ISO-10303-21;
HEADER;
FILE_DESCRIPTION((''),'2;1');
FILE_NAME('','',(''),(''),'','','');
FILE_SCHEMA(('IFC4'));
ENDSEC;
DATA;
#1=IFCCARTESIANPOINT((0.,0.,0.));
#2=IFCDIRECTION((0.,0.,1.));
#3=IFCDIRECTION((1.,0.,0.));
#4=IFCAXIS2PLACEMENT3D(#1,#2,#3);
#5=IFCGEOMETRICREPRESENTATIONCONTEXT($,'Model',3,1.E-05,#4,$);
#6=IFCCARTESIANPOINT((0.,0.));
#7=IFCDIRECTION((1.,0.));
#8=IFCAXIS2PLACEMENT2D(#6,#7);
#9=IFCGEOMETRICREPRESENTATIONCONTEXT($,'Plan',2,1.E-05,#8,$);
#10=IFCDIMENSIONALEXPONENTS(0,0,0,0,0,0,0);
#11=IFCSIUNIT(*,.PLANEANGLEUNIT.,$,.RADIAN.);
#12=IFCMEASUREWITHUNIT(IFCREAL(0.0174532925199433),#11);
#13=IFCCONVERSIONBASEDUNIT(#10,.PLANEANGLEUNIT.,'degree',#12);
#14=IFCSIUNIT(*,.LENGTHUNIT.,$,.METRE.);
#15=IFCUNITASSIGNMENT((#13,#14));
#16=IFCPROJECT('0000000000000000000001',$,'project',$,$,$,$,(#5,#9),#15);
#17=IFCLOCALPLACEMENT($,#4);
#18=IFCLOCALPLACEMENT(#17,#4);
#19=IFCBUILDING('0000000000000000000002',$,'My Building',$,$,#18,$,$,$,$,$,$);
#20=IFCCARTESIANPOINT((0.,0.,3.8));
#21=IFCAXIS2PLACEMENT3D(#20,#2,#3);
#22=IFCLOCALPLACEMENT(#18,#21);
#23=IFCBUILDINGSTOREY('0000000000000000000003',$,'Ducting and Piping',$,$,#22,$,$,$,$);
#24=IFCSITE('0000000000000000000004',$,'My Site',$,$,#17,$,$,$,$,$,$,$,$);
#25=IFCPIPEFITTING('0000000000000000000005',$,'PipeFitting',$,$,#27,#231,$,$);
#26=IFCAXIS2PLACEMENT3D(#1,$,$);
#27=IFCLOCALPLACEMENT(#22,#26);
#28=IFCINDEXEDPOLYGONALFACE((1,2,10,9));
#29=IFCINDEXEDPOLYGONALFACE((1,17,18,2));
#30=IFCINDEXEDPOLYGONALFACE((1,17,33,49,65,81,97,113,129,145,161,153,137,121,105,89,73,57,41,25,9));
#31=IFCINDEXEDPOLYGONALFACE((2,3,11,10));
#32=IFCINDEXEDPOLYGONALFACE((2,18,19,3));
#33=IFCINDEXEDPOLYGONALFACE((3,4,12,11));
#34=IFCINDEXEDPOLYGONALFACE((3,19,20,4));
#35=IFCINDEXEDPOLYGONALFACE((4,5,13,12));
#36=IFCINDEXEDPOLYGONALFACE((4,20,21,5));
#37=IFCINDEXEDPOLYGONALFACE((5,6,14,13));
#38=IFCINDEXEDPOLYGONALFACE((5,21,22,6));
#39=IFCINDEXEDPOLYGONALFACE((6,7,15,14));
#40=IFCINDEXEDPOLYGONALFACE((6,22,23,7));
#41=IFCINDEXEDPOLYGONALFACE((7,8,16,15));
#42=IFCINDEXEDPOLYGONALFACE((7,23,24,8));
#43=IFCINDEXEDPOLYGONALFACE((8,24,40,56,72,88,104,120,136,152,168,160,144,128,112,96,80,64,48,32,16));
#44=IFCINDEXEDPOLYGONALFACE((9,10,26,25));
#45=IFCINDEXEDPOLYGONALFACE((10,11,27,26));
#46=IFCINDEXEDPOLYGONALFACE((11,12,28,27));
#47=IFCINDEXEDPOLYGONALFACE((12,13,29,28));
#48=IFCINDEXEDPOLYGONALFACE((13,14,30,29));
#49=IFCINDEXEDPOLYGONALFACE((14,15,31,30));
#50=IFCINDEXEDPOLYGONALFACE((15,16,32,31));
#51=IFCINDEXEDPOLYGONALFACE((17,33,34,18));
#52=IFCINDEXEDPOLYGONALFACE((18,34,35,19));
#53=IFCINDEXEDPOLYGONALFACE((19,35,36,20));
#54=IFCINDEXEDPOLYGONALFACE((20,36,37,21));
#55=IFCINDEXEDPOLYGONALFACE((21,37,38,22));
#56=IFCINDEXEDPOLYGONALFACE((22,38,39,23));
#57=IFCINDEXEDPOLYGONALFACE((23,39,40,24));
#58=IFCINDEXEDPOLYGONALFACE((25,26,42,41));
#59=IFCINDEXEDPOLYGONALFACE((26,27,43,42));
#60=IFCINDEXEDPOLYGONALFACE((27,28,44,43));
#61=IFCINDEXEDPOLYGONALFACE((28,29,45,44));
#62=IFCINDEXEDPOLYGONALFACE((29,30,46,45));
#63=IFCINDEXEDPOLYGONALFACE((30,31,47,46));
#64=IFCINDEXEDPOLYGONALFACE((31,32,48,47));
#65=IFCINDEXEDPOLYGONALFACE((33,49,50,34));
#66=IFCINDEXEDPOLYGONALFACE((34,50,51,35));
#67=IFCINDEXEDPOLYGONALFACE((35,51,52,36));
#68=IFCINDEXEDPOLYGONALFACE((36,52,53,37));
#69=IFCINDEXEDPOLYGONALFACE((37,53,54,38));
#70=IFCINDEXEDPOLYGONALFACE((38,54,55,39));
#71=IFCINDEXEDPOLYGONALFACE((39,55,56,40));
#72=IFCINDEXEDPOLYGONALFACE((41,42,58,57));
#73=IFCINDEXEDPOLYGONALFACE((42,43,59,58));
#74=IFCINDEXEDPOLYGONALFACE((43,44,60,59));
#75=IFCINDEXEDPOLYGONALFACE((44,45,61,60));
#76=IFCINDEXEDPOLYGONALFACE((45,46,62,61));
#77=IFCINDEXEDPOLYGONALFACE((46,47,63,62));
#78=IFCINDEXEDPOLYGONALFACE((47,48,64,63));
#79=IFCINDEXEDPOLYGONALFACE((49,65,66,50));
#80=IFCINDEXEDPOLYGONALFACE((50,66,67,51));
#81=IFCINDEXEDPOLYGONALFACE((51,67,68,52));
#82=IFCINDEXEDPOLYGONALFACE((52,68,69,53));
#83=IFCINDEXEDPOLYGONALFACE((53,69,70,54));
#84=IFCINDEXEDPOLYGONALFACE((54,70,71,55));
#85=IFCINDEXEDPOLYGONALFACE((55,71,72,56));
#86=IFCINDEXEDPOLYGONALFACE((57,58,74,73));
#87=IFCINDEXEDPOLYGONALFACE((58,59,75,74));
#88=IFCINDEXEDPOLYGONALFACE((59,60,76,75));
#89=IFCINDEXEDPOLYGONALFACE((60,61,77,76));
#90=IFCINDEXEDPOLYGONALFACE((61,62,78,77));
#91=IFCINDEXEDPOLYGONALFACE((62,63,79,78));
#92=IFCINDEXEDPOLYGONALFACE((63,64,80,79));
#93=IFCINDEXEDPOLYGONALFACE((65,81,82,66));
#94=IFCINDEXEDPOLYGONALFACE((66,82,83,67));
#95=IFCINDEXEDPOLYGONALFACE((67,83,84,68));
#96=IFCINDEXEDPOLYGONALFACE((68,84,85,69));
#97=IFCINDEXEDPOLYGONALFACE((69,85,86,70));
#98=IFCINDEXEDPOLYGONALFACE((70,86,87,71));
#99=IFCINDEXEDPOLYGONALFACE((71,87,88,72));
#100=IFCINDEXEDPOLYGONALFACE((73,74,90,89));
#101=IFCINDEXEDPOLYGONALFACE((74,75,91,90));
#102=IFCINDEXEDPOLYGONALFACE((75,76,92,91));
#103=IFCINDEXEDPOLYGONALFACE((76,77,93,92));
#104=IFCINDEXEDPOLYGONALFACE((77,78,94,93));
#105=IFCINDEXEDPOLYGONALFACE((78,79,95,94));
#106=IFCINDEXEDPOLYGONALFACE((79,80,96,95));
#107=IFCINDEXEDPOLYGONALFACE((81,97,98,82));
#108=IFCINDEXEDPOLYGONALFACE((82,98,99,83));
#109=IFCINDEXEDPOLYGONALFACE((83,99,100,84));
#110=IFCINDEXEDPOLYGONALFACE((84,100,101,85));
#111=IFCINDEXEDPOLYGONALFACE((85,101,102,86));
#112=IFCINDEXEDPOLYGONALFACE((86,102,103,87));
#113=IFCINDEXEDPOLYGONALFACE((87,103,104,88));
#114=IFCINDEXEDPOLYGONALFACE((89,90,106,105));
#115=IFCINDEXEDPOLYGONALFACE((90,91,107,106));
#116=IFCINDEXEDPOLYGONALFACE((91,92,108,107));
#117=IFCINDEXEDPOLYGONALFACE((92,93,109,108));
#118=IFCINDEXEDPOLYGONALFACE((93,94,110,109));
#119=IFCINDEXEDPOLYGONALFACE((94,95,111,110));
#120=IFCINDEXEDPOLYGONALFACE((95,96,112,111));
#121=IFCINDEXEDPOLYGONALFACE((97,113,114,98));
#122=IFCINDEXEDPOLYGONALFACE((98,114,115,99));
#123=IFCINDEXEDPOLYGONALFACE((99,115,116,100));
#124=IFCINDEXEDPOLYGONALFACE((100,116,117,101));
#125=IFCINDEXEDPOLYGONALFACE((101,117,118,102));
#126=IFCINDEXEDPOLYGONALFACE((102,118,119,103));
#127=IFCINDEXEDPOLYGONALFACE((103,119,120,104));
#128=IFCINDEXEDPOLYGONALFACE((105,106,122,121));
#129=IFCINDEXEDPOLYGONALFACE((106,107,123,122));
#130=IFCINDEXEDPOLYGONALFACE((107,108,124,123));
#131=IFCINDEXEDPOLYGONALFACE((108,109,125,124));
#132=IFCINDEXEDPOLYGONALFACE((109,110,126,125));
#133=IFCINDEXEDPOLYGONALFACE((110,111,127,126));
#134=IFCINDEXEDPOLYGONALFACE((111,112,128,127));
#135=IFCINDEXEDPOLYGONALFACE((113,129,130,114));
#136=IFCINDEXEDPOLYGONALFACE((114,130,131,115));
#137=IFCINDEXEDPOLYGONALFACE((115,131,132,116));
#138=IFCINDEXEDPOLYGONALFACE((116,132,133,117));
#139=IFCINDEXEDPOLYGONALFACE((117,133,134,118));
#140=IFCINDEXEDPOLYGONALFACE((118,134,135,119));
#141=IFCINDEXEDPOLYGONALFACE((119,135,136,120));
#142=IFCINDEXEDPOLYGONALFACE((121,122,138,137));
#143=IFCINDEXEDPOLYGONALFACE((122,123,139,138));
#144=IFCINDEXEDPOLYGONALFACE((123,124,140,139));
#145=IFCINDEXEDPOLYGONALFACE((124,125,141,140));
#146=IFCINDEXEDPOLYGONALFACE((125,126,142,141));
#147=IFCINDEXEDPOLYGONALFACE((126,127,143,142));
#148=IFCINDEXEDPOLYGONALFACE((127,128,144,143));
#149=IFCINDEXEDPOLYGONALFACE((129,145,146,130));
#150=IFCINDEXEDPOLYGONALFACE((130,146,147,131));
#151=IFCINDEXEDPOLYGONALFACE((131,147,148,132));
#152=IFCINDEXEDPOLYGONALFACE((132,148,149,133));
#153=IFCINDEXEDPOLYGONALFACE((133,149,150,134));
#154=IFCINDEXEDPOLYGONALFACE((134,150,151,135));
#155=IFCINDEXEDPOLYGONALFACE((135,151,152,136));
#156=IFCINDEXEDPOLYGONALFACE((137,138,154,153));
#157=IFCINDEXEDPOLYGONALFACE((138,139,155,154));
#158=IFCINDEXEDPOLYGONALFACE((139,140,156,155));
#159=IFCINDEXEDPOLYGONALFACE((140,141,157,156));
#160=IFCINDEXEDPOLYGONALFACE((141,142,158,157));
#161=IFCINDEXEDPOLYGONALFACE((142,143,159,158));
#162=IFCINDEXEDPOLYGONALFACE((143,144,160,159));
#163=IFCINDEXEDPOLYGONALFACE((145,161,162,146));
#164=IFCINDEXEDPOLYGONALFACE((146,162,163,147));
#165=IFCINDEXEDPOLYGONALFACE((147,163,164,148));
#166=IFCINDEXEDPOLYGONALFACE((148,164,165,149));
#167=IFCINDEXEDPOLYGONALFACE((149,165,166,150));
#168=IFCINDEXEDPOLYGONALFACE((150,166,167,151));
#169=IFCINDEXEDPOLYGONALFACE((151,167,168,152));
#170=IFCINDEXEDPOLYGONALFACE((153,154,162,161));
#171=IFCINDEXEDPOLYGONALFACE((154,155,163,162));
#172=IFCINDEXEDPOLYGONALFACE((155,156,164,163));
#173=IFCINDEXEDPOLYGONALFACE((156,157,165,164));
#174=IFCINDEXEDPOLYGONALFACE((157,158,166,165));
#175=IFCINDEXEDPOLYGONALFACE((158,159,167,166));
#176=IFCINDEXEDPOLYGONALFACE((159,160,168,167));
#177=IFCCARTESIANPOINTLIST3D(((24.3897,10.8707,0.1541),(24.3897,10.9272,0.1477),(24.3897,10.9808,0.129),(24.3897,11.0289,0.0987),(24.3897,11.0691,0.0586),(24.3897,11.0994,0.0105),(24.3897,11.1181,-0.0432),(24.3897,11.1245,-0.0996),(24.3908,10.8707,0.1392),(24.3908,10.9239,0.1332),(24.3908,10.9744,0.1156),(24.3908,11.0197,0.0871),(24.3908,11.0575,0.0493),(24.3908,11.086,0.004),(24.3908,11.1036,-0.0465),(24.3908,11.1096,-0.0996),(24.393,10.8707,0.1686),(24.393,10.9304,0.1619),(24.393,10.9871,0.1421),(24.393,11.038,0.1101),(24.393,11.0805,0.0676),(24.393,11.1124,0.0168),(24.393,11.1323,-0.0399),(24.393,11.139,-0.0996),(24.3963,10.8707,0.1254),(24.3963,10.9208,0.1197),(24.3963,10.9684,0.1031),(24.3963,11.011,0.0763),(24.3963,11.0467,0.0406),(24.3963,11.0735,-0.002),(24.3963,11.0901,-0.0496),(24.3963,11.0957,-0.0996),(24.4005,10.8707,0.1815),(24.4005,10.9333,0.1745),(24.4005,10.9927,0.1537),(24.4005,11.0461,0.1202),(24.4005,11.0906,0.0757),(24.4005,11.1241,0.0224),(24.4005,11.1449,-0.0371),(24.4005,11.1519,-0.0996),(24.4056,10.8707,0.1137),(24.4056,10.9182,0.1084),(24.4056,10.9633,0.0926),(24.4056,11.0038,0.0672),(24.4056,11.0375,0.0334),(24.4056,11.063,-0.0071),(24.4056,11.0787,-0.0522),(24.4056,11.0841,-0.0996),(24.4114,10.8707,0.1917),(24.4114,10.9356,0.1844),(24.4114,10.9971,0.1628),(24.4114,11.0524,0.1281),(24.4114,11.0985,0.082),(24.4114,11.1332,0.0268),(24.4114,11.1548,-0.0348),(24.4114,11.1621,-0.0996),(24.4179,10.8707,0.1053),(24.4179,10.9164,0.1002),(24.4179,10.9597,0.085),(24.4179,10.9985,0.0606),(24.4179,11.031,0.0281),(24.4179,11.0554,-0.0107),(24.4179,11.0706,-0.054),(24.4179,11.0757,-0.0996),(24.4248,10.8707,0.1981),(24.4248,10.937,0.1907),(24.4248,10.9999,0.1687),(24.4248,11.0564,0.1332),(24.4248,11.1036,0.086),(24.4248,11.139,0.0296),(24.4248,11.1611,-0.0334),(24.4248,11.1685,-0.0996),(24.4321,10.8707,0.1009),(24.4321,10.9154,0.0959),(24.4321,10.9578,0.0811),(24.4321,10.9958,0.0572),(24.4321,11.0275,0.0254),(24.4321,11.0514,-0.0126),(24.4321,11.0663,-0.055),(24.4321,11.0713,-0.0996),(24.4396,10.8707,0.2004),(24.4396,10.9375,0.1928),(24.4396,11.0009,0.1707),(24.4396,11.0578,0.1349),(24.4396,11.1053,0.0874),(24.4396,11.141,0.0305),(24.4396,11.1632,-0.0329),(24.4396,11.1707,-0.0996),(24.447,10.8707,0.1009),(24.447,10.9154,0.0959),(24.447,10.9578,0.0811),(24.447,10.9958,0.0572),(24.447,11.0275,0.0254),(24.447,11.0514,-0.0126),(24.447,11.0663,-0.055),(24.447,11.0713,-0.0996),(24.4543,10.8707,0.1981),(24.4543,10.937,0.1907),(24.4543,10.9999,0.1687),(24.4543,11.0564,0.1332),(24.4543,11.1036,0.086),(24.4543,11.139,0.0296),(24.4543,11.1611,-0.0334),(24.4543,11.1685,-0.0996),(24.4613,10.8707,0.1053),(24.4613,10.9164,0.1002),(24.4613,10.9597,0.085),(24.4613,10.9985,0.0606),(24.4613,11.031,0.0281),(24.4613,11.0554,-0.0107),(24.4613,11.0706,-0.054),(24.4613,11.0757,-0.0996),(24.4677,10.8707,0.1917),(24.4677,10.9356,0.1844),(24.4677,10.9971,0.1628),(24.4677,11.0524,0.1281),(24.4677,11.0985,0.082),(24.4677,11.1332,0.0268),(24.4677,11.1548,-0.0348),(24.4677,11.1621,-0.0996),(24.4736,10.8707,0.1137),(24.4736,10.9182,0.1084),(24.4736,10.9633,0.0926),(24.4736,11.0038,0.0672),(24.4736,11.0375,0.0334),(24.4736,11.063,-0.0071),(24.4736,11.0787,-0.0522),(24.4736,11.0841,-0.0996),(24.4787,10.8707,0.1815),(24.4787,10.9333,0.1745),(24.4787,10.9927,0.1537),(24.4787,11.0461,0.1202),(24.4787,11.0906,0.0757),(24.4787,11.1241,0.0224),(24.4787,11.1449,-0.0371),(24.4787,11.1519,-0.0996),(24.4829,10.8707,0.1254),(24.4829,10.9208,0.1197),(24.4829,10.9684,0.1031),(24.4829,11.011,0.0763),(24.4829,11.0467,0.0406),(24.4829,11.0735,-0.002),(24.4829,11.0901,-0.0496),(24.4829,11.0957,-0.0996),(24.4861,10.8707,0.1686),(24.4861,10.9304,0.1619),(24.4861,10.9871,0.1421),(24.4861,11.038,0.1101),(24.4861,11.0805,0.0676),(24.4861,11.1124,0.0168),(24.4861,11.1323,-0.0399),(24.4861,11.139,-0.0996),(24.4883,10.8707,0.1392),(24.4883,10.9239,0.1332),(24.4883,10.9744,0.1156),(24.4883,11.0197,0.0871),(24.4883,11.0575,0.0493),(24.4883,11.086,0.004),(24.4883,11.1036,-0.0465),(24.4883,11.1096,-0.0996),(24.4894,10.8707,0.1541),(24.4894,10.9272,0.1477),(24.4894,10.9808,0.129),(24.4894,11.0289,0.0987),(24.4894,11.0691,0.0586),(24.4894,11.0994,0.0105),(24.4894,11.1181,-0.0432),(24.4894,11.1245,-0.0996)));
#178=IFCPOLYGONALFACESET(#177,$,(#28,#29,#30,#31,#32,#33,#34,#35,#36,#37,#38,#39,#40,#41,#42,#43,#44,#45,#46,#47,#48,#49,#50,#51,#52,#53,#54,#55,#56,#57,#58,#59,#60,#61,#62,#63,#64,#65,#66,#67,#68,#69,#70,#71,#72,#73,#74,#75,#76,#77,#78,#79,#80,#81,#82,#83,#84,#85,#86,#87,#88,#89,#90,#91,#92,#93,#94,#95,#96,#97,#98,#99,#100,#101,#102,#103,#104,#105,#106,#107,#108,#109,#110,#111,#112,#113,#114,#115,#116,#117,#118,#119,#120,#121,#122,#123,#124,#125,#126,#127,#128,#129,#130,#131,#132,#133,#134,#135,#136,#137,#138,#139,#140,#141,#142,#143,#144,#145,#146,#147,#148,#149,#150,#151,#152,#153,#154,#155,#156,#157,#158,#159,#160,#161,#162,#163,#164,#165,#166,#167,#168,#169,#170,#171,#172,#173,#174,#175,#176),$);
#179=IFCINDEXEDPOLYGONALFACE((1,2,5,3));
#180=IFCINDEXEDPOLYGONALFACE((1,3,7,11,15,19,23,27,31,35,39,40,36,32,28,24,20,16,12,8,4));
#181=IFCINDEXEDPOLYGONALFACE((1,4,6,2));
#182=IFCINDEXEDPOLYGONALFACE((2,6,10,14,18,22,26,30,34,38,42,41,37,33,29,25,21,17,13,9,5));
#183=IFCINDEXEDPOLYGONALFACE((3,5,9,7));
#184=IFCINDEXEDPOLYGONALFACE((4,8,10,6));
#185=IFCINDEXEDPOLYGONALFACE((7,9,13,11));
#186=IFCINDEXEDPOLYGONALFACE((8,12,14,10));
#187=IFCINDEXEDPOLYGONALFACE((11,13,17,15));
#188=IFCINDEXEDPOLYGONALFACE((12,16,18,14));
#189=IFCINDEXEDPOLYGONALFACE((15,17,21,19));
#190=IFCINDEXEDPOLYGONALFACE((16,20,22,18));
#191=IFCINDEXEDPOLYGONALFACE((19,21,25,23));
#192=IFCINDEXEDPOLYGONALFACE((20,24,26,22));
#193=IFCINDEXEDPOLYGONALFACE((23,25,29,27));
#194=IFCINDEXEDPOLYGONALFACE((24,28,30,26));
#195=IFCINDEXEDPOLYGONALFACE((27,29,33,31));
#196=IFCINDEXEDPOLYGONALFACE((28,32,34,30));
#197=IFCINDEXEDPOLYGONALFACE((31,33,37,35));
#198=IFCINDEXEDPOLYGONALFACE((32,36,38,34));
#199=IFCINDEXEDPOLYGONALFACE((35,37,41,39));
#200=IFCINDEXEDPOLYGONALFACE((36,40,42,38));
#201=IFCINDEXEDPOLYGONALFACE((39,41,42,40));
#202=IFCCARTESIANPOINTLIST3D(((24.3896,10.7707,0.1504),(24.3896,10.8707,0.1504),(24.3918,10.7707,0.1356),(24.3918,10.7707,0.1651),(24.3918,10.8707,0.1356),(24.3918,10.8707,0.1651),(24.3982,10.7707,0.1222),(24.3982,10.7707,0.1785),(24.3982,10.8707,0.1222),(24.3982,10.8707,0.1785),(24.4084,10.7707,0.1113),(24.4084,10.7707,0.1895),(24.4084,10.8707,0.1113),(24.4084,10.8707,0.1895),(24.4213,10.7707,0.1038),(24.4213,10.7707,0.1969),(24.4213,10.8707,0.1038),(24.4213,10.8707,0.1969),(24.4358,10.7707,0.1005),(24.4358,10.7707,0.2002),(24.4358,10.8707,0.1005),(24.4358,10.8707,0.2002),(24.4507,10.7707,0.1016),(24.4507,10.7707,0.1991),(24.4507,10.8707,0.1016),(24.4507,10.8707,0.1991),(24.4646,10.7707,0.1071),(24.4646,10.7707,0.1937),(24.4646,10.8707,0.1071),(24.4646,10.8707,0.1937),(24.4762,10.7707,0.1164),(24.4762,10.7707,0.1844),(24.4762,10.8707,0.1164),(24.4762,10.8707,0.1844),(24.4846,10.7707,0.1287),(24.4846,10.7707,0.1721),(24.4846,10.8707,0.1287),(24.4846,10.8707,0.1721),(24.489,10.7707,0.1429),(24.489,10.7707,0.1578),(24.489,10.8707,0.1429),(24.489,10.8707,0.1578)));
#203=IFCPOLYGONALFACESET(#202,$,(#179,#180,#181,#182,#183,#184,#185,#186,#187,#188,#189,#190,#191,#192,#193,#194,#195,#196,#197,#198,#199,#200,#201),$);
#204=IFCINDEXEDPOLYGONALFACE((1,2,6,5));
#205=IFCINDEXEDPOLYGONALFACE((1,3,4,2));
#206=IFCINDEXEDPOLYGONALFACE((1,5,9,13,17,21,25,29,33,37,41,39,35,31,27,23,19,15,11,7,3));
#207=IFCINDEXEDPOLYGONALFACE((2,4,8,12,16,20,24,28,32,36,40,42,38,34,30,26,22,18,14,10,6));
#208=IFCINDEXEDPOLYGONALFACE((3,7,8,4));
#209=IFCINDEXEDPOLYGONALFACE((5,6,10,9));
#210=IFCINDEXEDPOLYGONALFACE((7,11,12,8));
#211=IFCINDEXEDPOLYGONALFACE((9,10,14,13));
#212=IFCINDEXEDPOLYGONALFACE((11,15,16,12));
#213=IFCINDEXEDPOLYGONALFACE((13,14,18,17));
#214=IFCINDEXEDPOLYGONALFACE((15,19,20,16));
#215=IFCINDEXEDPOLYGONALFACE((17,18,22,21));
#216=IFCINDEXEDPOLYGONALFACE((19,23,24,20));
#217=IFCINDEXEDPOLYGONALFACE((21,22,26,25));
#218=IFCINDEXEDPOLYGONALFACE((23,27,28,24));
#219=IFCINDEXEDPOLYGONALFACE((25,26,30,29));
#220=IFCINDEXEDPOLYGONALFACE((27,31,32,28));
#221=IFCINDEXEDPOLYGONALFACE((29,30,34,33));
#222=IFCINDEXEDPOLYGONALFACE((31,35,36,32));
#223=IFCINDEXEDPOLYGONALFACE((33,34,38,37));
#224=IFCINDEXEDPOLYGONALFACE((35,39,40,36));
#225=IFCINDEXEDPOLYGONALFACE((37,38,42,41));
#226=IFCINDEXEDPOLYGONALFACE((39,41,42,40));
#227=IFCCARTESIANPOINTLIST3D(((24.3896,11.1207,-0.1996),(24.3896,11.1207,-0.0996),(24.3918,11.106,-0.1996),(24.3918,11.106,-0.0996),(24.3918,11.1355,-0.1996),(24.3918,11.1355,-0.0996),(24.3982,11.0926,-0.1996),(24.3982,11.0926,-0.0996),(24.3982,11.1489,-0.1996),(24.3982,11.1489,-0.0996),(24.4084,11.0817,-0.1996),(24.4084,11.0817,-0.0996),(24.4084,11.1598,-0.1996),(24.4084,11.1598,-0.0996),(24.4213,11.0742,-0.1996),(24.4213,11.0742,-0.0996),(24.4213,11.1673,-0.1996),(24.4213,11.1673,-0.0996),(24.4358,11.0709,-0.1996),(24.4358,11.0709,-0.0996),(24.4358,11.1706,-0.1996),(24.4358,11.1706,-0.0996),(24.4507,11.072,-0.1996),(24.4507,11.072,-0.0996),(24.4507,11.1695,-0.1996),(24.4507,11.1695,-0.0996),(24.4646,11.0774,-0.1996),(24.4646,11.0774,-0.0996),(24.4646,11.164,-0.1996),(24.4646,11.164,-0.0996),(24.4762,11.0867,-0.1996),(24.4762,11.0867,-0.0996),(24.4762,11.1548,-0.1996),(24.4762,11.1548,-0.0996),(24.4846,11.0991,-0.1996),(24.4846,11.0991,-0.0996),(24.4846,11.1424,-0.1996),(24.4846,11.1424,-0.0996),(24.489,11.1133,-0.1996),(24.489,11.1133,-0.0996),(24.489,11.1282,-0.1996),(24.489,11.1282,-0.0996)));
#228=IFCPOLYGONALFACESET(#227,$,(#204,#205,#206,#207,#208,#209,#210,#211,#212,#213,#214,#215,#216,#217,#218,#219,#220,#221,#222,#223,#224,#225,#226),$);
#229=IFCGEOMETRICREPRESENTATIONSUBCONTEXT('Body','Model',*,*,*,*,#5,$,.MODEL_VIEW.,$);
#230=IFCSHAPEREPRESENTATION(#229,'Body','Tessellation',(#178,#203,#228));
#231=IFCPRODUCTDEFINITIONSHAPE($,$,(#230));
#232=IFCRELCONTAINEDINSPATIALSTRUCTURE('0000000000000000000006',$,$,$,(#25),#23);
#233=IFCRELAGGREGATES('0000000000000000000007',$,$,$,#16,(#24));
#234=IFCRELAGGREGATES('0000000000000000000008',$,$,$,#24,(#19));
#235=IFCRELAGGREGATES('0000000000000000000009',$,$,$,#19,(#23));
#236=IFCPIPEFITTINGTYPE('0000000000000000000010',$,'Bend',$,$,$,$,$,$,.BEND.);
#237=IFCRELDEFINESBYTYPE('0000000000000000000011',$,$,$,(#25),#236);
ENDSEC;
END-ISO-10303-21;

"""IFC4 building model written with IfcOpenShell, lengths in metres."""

from ifc_helpers import new_model, entity, si_unit, converted_unit, frame, origin_with_axes, origin_2d_with_axis, place, context, subcontext, project, spatial, circle, extrude, source, transform, mapped, type_object, type_shapes, element, save


model = new_model("IFC4")

# Units and contexts
model_context = context("Model", 3, precision=1e-05, world=origin_with_axes())
plan_context = context("Plan", 2, precision=1e-05, world=origin_2d_with_axis())
body_context = subcontext(model_context, "Body", "Model", "MODEL_VIEW")
ifc_project = project(units=[converted_unit("PLANEANGLEUNIT", "degree", entity("IfcReal", 0.0174532925199433), si_unit("PLANEANGLEUNIT", "RADIAN"), dimensions=[0, 0, 0, 0, 0, 0, 0]), si_unit("LENGTHUNIT", "METRE")], contexts=[model_context, plan_context])

# Site, building, storey
site_placement = place(None, origin_with_axes())
site = spatial("IfcSite", under=ifc_project, at=site_placement, Name="My Site")
building_placement = place(site_placement, origin_with_axes())
building = spatial("IfcBuilding", under=site, at=building_placement, Name="My Building")
storey_placement = place(building_placement, frame((0.0, 0.0, 3.8), z_axis=(0.0, 0.0, 1.0), x_axis=(1.0, 0.0, 0.0)))
storey = spatial("IfcBuildingStorey", under=building, at=storey_placement, Name="Ducting and Piping")

# Pipe fitting
pipe_fitting_type = type_object("IfcPipeFittingType", Name="Bend", PredefinedType="BEND")
shared_shape = source(origin_with_axes(), body_context, "Body", "SolidModel", [
    entity("IfcSweptDiskSolid", entity("IfcIndexedPolyCurve", entity("IfcCartesianPointList3D", [[0.0, 0.0, 0.1], [0.0, -0.0732, 0.2768], [0.0, -0.25, 0.35]]), [entity("IfcArcIndex", [1, 2, 3])]), 0.05),
    extrude(circle(Radius=0.05), origin_with_axes(), (0.0, 0.0, 1.0), 0.1),
    extrude(circle(Radius=0.05), frame((0.0, -0.25, 0.35), z_axis=(0.0, -1.0, 0.0), x_axis=(1.0, 0.0, 0.0)), (0.0, 0.0, 1.0), 0.1),
])
type_shapes(pipe_fitting_type, [shared_shape])
for number, where, z_axis, x_axis, name in (
    (1, (24.4396, 10.7707, 0.1504), (0.0, 1.0, 0.0), (-1.0, 0.0, 0.0), "PipeFitting"),
):
    element("IfcPipeFitting", number, at=place(storey_placement, frame(where, z_axis=z_axis, x_axis=x_axis)), inside=storey, type_object=pipe_fitting_type, Name=name, context=body_context, shape_type="MappedRepresentation", body=[
        mapped(shared_shape, transform((0.0, 0.0, 0.0), x_axis=(1.0, 0.0, 0.0), y_axis=(0.0, 1.0, 0.0), z_axis=(0.0, 0.0, 1.0), scale=1.0)),
    ])

save(model, "model.ifc")
